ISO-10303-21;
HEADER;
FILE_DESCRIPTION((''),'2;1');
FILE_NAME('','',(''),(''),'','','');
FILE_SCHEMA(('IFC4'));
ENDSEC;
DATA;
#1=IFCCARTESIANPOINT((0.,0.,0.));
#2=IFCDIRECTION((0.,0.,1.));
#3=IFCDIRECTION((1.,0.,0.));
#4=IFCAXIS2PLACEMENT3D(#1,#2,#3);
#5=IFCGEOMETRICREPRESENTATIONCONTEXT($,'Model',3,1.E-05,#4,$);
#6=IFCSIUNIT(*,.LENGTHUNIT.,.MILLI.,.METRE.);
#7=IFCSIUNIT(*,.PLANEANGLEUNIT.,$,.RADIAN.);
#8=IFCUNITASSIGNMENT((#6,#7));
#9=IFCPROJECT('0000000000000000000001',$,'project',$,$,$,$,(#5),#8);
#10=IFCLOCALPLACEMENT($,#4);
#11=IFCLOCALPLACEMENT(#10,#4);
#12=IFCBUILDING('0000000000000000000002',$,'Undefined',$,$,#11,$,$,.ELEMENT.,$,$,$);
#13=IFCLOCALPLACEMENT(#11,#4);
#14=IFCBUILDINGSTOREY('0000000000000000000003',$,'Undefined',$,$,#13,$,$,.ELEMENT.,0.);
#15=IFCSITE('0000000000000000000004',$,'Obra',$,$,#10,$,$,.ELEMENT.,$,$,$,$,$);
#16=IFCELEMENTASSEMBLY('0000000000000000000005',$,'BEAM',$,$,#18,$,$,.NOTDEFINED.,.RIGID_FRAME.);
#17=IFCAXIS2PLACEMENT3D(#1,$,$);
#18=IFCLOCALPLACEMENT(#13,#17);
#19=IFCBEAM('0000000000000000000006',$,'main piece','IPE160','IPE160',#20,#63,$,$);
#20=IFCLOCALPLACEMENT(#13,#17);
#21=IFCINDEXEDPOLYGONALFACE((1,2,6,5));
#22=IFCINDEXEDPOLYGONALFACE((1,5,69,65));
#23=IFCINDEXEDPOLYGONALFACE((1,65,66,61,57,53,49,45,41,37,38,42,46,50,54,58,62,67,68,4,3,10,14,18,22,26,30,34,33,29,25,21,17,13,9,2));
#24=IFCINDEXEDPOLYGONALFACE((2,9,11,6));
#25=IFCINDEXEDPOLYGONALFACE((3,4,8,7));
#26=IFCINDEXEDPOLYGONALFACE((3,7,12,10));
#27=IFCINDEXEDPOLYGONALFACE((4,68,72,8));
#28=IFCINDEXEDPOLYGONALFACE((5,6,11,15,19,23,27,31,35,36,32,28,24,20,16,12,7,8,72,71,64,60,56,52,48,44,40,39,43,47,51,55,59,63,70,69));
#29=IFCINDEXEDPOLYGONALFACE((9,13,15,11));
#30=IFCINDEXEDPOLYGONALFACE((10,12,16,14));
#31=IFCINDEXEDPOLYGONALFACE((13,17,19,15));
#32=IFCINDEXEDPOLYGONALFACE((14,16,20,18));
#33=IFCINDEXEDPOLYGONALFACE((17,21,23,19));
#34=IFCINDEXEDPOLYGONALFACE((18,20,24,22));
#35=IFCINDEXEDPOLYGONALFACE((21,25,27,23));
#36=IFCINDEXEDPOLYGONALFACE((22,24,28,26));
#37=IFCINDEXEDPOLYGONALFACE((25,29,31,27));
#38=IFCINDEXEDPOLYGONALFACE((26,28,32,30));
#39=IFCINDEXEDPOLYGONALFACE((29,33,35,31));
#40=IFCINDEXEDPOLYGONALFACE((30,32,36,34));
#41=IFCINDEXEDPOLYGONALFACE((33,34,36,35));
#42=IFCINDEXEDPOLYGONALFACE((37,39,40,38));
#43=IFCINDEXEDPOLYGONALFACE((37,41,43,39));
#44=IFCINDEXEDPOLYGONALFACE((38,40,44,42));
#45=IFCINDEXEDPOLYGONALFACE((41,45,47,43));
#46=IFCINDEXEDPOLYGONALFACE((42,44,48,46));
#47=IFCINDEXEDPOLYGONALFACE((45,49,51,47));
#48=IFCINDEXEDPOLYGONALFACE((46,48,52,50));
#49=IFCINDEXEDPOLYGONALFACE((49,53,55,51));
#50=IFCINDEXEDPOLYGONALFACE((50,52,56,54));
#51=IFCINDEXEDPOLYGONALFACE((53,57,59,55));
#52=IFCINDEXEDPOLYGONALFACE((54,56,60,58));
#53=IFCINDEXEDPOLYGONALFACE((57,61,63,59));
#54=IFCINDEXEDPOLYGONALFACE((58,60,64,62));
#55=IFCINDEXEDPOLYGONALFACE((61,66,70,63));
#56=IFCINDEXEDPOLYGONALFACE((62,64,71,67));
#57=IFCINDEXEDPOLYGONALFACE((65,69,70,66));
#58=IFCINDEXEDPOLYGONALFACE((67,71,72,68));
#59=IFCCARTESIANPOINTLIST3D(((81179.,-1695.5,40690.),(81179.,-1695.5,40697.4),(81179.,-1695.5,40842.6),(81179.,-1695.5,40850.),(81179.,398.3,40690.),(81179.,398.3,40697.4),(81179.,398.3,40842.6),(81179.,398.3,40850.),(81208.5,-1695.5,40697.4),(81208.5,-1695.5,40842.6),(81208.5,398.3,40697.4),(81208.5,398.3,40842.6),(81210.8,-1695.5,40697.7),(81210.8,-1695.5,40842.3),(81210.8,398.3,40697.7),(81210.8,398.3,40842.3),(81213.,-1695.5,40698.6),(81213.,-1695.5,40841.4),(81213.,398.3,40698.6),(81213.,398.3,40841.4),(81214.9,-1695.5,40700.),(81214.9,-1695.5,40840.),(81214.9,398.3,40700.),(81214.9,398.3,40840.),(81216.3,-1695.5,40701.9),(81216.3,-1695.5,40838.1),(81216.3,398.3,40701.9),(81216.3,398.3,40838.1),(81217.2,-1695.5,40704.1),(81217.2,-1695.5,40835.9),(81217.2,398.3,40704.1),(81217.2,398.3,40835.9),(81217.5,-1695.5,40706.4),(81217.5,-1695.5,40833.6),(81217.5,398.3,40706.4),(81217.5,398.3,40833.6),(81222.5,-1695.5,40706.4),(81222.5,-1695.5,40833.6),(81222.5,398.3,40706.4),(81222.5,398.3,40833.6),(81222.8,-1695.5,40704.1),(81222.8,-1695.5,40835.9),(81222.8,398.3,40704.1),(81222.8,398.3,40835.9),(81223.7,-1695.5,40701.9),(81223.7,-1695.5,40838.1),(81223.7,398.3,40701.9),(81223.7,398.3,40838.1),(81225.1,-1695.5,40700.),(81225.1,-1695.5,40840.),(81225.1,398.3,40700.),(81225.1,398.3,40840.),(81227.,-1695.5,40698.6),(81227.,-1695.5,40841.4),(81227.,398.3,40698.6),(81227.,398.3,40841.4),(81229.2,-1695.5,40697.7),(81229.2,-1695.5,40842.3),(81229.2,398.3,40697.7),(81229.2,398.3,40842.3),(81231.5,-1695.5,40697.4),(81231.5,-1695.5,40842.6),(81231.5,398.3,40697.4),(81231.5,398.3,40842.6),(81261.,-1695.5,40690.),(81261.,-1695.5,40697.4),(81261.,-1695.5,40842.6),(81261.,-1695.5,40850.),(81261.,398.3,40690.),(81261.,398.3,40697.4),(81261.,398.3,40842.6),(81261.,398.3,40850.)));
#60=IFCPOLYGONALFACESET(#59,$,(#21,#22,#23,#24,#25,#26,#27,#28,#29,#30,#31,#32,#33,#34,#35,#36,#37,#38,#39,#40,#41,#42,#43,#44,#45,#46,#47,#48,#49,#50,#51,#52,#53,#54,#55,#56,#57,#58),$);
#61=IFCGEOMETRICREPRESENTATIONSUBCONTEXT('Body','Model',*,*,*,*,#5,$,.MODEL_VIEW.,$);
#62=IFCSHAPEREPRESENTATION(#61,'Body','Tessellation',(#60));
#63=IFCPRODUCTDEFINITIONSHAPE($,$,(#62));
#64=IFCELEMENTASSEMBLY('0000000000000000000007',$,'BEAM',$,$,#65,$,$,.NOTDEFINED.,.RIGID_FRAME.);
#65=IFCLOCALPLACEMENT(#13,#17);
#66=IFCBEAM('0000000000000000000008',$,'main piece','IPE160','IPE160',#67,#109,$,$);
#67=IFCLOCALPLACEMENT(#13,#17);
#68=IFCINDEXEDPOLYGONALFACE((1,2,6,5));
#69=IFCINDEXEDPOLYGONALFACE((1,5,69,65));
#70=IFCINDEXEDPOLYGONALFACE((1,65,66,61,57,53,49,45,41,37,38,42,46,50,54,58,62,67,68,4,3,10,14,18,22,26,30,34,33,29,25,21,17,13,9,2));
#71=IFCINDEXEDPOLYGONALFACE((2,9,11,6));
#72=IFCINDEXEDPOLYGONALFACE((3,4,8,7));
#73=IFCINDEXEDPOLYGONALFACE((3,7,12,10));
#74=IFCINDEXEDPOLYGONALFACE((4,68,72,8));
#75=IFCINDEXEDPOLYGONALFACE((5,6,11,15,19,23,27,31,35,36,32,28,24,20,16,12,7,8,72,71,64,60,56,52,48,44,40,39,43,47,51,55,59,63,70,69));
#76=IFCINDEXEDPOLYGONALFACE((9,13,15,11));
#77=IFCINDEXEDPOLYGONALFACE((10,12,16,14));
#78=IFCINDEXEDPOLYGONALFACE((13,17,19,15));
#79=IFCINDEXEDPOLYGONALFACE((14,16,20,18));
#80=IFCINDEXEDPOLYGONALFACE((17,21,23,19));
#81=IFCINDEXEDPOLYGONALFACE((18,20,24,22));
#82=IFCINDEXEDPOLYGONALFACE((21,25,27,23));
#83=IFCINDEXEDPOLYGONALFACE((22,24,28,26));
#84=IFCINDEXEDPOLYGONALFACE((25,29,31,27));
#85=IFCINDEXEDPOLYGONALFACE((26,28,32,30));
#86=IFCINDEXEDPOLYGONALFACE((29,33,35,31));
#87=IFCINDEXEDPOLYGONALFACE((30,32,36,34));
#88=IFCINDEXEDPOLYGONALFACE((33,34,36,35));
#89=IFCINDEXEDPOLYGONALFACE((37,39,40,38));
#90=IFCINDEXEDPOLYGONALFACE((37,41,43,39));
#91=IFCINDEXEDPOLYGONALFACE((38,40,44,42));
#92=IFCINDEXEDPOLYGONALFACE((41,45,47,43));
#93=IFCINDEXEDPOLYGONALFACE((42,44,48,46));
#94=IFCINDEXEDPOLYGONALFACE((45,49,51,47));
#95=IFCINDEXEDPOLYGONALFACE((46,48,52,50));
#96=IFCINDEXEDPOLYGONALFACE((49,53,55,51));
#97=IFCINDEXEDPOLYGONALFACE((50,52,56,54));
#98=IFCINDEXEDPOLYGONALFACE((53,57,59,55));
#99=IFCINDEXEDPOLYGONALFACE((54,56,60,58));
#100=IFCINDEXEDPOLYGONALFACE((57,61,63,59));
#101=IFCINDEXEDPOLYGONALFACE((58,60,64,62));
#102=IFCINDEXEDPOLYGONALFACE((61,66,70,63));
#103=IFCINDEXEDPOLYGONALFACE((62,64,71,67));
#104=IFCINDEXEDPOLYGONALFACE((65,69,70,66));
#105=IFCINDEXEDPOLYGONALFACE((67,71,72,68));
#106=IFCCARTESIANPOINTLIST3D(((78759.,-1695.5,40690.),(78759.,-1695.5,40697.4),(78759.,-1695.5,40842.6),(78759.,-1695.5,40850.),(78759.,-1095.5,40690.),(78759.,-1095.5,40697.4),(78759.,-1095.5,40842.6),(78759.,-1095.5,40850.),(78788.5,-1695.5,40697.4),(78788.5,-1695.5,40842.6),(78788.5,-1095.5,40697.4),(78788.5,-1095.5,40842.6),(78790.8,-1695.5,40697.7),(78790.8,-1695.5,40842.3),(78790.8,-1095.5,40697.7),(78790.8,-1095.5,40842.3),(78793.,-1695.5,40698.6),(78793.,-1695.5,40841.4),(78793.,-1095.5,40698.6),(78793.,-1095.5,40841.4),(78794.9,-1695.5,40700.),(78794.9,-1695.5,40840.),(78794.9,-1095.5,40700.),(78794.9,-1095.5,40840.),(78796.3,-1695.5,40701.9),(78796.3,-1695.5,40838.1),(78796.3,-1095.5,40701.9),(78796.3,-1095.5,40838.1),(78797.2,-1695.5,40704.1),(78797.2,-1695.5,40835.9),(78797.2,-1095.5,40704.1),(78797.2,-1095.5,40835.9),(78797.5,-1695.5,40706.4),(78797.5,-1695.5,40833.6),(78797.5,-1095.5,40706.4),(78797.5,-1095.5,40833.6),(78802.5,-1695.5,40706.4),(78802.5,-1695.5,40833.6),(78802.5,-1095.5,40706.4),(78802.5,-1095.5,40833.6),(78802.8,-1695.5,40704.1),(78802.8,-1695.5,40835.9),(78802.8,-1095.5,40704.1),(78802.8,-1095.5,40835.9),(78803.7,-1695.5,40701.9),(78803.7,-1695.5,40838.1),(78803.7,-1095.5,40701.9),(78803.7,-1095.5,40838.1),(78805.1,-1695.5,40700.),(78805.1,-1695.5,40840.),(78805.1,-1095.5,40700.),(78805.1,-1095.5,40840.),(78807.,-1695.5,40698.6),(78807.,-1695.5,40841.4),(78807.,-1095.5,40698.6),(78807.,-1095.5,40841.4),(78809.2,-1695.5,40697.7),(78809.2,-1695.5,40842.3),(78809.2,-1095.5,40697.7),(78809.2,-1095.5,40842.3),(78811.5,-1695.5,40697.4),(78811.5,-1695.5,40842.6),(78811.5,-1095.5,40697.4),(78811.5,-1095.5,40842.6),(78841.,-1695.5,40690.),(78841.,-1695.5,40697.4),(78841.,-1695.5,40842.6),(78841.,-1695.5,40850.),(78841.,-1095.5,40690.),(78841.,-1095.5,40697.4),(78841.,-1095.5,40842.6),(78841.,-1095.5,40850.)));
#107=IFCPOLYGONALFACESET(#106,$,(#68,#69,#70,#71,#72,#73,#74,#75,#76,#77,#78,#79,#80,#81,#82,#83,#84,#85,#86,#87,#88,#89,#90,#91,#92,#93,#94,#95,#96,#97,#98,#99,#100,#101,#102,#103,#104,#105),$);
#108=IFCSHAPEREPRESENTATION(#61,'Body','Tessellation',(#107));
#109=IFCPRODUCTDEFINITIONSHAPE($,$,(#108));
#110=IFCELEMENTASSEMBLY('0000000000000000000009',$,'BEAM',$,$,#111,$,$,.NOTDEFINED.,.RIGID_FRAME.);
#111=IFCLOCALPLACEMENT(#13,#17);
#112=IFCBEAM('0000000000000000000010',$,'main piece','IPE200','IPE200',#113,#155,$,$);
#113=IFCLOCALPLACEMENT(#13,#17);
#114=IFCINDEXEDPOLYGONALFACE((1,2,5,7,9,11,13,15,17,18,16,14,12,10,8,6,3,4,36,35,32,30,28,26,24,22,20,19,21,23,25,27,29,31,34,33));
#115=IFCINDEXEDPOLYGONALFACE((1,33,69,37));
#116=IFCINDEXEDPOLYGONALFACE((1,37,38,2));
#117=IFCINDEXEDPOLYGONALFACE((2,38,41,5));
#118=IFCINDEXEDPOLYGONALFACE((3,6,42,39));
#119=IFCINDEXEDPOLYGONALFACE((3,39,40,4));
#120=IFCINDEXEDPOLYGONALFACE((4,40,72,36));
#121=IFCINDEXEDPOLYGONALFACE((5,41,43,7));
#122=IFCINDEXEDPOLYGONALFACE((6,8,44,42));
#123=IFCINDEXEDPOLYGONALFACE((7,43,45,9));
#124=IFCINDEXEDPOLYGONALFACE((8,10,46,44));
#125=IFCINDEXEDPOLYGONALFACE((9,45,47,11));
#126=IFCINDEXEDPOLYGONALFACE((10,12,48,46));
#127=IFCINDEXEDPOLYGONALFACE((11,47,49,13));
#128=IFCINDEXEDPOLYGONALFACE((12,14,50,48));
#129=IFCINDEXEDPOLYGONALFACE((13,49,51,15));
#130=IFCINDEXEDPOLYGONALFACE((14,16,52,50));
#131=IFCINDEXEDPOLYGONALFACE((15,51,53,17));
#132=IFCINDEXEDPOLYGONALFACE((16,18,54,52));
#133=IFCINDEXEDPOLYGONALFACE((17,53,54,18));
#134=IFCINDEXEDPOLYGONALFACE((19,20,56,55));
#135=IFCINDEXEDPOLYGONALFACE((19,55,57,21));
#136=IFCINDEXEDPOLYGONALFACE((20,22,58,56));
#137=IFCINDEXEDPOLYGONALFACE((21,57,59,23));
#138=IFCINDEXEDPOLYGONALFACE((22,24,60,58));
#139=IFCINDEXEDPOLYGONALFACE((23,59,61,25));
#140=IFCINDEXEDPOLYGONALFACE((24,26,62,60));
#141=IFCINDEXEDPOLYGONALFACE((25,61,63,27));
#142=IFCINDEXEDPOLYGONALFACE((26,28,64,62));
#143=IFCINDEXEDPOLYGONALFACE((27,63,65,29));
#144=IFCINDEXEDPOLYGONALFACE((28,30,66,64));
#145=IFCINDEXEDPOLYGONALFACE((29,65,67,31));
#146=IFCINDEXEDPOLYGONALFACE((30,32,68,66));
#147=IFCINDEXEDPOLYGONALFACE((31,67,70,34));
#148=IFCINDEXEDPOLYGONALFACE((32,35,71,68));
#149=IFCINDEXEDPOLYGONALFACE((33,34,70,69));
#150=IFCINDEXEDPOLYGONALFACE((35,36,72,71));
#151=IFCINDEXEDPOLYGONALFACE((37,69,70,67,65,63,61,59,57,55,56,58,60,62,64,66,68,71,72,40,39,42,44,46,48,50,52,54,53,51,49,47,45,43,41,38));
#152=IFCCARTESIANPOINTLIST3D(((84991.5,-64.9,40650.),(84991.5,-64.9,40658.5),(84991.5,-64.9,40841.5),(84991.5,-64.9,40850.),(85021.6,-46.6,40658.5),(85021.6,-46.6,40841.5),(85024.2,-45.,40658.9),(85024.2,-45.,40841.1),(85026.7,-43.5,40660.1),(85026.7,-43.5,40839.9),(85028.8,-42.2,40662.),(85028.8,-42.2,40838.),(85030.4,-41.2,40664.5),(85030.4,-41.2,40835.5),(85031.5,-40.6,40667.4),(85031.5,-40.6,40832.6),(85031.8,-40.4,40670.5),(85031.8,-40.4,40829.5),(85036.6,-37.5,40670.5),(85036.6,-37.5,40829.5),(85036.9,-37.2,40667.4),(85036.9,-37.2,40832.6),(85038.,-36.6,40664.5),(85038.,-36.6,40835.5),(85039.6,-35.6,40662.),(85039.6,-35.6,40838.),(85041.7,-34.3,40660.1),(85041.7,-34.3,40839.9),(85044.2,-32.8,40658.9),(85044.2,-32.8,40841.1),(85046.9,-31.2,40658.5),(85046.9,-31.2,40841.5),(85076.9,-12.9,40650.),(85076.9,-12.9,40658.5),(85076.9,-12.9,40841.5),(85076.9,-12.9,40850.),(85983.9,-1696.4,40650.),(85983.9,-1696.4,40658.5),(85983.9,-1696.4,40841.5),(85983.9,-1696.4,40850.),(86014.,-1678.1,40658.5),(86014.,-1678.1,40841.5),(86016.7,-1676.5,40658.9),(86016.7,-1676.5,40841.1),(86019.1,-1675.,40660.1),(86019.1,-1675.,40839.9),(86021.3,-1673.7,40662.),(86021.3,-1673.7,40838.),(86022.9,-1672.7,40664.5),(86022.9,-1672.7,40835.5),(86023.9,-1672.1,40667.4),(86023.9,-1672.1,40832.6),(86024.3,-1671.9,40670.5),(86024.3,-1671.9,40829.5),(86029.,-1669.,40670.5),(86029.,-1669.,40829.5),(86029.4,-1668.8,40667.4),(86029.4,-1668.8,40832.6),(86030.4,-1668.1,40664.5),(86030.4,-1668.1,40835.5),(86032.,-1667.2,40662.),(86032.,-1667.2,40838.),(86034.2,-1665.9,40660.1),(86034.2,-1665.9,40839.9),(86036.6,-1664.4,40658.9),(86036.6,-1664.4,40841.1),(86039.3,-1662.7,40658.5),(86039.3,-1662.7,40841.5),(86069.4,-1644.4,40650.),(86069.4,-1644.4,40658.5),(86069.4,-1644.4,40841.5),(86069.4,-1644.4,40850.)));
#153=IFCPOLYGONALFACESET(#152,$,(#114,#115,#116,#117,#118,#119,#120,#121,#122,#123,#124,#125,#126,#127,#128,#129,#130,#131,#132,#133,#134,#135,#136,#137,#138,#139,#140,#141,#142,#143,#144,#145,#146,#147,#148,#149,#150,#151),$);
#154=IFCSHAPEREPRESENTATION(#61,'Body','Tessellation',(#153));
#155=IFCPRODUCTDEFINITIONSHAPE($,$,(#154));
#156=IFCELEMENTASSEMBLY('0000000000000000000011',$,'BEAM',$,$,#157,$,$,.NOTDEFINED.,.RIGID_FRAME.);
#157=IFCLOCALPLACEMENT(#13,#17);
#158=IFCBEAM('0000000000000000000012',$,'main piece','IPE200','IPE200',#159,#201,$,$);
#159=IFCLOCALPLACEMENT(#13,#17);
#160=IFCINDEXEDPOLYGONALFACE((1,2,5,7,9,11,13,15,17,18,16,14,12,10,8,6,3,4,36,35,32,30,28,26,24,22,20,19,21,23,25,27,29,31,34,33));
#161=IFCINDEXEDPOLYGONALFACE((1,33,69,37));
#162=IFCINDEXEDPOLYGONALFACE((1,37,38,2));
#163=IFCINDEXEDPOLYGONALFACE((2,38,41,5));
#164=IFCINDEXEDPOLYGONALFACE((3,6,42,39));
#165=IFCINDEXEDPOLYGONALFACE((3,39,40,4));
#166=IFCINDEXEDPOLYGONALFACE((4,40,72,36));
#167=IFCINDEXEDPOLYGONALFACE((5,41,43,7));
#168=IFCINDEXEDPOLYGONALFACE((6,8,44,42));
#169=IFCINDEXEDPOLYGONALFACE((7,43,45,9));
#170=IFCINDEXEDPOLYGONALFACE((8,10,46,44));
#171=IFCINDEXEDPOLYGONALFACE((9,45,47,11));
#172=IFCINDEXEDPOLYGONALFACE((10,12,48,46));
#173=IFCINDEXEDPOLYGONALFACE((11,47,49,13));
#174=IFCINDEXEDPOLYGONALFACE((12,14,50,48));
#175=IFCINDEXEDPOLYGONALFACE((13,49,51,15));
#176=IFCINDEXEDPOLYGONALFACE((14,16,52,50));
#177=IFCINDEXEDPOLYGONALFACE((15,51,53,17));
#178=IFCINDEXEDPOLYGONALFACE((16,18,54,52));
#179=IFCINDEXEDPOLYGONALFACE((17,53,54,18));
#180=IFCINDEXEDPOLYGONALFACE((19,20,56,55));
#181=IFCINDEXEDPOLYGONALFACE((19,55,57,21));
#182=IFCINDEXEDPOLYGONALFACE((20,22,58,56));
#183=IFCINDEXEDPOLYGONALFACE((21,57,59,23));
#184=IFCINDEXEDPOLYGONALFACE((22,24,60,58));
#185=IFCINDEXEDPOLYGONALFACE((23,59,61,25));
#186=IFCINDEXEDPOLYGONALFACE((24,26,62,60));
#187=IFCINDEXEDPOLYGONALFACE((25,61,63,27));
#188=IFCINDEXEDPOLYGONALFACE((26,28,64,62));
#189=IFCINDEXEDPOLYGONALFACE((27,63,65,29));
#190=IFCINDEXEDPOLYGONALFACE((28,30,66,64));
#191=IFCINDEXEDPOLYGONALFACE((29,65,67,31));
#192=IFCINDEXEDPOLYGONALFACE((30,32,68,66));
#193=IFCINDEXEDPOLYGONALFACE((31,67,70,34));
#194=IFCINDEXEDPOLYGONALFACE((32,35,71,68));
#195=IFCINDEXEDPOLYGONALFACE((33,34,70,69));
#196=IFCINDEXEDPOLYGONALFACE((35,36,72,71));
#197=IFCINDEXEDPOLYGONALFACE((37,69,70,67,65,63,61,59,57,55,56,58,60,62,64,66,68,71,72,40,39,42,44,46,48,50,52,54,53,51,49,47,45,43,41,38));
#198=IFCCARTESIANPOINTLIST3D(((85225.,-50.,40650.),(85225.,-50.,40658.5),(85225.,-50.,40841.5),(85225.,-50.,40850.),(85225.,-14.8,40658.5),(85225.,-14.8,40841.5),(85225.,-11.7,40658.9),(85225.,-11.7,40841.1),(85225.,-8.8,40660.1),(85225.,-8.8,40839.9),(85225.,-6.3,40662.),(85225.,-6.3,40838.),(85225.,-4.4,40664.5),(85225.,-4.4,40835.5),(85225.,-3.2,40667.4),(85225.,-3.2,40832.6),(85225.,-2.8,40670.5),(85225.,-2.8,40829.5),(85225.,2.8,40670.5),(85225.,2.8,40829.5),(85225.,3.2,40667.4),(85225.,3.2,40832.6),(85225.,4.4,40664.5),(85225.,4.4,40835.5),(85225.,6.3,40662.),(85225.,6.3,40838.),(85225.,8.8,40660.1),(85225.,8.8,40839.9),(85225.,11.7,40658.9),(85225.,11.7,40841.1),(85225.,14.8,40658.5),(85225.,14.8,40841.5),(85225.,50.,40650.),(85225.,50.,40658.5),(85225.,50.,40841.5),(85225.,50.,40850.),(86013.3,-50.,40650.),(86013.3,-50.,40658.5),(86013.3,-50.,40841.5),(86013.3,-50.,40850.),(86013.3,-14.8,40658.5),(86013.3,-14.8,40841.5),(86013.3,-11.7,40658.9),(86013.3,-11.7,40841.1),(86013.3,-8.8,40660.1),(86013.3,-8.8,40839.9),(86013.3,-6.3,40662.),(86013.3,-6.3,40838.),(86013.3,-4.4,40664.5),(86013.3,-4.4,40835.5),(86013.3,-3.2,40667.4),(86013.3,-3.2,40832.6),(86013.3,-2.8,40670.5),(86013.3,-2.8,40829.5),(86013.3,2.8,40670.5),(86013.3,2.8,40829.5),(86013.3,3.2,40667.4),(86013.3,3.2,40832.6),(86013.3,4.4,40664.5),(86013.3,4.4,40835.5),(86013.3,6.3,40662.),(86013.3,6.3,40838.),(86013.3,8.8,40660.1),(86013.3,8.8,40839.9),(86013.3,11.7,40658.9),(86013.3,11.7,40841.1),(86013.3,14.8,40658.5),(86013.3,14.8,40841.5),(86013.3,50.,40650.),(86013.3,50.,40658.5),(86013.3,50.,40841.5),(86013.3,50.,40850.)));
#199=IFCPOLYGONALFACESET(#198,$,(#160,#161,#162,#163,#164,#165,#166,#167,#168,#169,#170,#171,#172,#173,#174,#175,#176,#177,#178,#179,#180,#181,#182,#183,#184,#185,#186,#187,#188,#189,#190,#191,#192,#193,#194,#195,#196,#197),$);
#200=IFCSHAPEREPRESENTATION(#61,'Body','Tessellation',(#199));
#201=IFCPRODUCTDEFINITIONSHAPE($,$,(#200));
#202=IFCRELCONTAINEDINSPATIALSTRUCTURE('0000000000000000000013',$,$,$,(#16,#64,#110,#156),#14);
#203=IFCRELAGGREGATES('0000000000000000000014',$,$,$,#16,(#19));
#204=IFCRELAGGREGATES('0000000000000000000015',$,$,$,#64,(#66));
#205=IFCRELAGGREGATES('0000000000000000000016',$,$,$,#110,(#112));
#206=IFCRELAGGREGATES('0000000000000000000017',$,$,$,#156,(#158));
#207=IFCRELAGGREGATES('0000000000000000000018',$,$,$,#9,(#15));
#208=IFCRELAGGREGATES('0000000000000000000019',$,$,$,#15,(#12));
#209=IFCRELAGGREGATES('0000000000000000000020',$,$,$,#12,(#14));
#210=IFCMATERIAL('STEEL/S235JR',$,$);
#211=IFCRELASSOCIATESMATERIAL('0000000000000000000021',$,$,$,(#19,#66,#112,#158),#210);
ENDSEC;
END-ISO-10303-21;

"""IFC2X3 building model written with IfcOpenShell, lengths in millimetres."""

from ifc_helpers import new_model, si_unit, frame, origin_with_axes, origin_2d_with_axis, place, context, subcontext, project, spatial, i_section, extrude, material, element, aggregate, save


model = new_model("IFC2X3")

# Units and contexts
model_context = context("Model", 3, precision=1e-05, world=origin_with_axes())
body_context = subcontext(model_context, "Body", "Model", "MODEL_VIEW")
ifc_project = project(units=[si_unit("LENGTHUNIT", "METRE", prefix="MILLI"), si_unit("PLANEANGLEUNIT", "RADIAN")], contexts=[model_context])

# Site, building, storey
site_placement = place(None, origin_with_axes())
site = spatial("IfcSite", under=ifc_project, at=site_placement, Name="Obra", CompositionType="ELEMENT")
building_placement = place(site_placement, origin_with_axes())
building = spatial("IfcBuilding", under=site, at=building_placement, Name="Undefined", CompositionType="ELEMENT")
storey_placement = place(building_placement, origin_with_axes())
storey = spatial("IfcBuildingStorey", under=building, at=storey_placement, Name="Undefined", CompositionType="ELEMENT", Elevation=0.0)

# Shared definitions
ifc_material_1 = material(Name="STEEL/S235JR")

# Element assemblies, beams
assembly_1_placement = place(storey_placement, origin_with_axes())
assembly_1 = element("IfcElementAssembly", 1, at=assembly_1_placement, inside=storey, Name="BEAM", AssemblyPlace="NOTDEFINED", PredefinedType="RIGID_FRAME")
beam_1_placement = place(assembly_1_placement, frame((81220.0, 398.3, 40770.0), z_axis=(0.0, 0.0, 1.0), x_axis=(0.0, -1.0, 0.0)))
beam_1 = element("IfcBeam", 2, at=beam_1_placement, material=ifc_material_1, Name="main piece", Description="IPE160", ObjectType="IPE160", context=body_context, shape_type="SweptSolid", body=[
    extrude(i_section(OverallWidth=82.0, OverallDepth=160.0, WebThickness=5.0, FlangeThickness=7.4, FilletRadius=9.0, at=origin_2d_with_axis()), frame((2093.8, 0.0, 0.0), z_axis=(-1.0, 0.0, 0.0), x_axis=(0.0, -1.0, 0.0)), (0.0, 0.0, 1.0), 2093.8),
])
aggregate(assembly_1, [beam_1])
assembly_2_placement = place(storey_placement, origin_with_axes())
assembly_2 = element("IfcElementAssembly", 3, at=assembly_2_placement, inside=storey, Name="BEAM", AssemblyPlace="NOTDEFINED", PredefinedType="RIGID_FRAME")
beam_2_placement = place(assembly_2_placement, frame((78800.0, -1095.5, 40770.0), z_axis=(0.0, 0.0, 1.0), x_axis=(0.0, -1.0, 0.0)))
beam_2 = element("IfcBeam", 4, at=beam_2_placement, material=ifc_material_1, Name="main piece", Description="IPE160", ObjectType="IPE160", context=body_context, shape_type="SweptSolid", body=[
    extrude(i_section(OverallWidth=82.0, OverallDepth=160.0, WebThickness=5.0, FlangeThickness=7.4, FilletRadius=9.0, at=origin_2d_with_axis()), frame((600.1, 0.0, 0.0), z_axis=(-1.0, 0.0, 0.0), x_axis=(0.0, -1.0, 0.0)), (0.0, 0.0, 1.0), 600.0),
])
aggregate(assembly_2, [beam_2])
assembly_3_placement = place(storey_placement, origin_with_axes())
assembly_3 = element("IfcElementAssembly", 5, at=assembly_3_placement, inside=storey, Name="BEAM", AssemblyPlace="NOTDEFINED", PredefinedType="RIGID_FRAME")
beam_3_placement = place(assembly_3_placement, frame((85034.2, -38.9, 40750.0), z_axis=(0.0, 0.0, 1.0), x_axis=(0.519695, -0.854352, 0.0)))
beam_3 = element("IfcBeam", 6, at=beam_3_placement, material=ifc_material_1, Name="main piece", Description="IPE200", ObjectType="IPE200", context=body_context, shape_type="SweptSolid", body=[
    extrude(i_section(OverallWidth=100.0, OverallDepth=200.0, WebThickness=5.6, FlangeThickness=8.5, FilletRadius=12.0, at=origin_2d_with_axis()), frame((1909.7, 0.0, 0.0), z_axis=(-1.0, 0.0, 0.0), x_axis=(0.0, -1.0, 0.0)), (0.0, 0.0, 1.0), 1909.7),
])
aggregate(assembly_3, [beam_3])
assembly_4_placement = place(storey_placement, origin_with_axes())
assembly_4 = element("IfcElementAssembly", 7, at=assembly_4_placement, inside=storey, Name="BEAM", AssemblyPlace="NOTDEFINED", PredefinedType="RIGID_FRAME")
beam_4_placement = place(assembly_4_placement, frame((85225.0, 0.0, 40750.0), z_axis=(0.0, 0.0, 1.0), x_axis=(1.0, 0.0, 0.0)))
beam_4 = element("IfcBeam", 8, at=beam_4_placement, material=ifc_material_1, Name="main piece", Description="IPE200", ObjectType="IPE200", context=body_context, shape_type="SweptSolid", body=[
    extrude(i_section(OverallWidth=100.0, OverallDepth=200.0, WebThickness=5.6, FlangeThickness=8.5, FilletRadius=12.0, at=origin_2d_with_axis()), frame((788.3, 0.0, 0.0), z_axis=(-1.0, 0.0, 0.0), x_axis=(0.0, -1.0, 0.0)), (0.0, 0.0, 1.0), 788.3),
])
aggregate(assembly_4, [beam_4])

save(model, "model.ifc")
